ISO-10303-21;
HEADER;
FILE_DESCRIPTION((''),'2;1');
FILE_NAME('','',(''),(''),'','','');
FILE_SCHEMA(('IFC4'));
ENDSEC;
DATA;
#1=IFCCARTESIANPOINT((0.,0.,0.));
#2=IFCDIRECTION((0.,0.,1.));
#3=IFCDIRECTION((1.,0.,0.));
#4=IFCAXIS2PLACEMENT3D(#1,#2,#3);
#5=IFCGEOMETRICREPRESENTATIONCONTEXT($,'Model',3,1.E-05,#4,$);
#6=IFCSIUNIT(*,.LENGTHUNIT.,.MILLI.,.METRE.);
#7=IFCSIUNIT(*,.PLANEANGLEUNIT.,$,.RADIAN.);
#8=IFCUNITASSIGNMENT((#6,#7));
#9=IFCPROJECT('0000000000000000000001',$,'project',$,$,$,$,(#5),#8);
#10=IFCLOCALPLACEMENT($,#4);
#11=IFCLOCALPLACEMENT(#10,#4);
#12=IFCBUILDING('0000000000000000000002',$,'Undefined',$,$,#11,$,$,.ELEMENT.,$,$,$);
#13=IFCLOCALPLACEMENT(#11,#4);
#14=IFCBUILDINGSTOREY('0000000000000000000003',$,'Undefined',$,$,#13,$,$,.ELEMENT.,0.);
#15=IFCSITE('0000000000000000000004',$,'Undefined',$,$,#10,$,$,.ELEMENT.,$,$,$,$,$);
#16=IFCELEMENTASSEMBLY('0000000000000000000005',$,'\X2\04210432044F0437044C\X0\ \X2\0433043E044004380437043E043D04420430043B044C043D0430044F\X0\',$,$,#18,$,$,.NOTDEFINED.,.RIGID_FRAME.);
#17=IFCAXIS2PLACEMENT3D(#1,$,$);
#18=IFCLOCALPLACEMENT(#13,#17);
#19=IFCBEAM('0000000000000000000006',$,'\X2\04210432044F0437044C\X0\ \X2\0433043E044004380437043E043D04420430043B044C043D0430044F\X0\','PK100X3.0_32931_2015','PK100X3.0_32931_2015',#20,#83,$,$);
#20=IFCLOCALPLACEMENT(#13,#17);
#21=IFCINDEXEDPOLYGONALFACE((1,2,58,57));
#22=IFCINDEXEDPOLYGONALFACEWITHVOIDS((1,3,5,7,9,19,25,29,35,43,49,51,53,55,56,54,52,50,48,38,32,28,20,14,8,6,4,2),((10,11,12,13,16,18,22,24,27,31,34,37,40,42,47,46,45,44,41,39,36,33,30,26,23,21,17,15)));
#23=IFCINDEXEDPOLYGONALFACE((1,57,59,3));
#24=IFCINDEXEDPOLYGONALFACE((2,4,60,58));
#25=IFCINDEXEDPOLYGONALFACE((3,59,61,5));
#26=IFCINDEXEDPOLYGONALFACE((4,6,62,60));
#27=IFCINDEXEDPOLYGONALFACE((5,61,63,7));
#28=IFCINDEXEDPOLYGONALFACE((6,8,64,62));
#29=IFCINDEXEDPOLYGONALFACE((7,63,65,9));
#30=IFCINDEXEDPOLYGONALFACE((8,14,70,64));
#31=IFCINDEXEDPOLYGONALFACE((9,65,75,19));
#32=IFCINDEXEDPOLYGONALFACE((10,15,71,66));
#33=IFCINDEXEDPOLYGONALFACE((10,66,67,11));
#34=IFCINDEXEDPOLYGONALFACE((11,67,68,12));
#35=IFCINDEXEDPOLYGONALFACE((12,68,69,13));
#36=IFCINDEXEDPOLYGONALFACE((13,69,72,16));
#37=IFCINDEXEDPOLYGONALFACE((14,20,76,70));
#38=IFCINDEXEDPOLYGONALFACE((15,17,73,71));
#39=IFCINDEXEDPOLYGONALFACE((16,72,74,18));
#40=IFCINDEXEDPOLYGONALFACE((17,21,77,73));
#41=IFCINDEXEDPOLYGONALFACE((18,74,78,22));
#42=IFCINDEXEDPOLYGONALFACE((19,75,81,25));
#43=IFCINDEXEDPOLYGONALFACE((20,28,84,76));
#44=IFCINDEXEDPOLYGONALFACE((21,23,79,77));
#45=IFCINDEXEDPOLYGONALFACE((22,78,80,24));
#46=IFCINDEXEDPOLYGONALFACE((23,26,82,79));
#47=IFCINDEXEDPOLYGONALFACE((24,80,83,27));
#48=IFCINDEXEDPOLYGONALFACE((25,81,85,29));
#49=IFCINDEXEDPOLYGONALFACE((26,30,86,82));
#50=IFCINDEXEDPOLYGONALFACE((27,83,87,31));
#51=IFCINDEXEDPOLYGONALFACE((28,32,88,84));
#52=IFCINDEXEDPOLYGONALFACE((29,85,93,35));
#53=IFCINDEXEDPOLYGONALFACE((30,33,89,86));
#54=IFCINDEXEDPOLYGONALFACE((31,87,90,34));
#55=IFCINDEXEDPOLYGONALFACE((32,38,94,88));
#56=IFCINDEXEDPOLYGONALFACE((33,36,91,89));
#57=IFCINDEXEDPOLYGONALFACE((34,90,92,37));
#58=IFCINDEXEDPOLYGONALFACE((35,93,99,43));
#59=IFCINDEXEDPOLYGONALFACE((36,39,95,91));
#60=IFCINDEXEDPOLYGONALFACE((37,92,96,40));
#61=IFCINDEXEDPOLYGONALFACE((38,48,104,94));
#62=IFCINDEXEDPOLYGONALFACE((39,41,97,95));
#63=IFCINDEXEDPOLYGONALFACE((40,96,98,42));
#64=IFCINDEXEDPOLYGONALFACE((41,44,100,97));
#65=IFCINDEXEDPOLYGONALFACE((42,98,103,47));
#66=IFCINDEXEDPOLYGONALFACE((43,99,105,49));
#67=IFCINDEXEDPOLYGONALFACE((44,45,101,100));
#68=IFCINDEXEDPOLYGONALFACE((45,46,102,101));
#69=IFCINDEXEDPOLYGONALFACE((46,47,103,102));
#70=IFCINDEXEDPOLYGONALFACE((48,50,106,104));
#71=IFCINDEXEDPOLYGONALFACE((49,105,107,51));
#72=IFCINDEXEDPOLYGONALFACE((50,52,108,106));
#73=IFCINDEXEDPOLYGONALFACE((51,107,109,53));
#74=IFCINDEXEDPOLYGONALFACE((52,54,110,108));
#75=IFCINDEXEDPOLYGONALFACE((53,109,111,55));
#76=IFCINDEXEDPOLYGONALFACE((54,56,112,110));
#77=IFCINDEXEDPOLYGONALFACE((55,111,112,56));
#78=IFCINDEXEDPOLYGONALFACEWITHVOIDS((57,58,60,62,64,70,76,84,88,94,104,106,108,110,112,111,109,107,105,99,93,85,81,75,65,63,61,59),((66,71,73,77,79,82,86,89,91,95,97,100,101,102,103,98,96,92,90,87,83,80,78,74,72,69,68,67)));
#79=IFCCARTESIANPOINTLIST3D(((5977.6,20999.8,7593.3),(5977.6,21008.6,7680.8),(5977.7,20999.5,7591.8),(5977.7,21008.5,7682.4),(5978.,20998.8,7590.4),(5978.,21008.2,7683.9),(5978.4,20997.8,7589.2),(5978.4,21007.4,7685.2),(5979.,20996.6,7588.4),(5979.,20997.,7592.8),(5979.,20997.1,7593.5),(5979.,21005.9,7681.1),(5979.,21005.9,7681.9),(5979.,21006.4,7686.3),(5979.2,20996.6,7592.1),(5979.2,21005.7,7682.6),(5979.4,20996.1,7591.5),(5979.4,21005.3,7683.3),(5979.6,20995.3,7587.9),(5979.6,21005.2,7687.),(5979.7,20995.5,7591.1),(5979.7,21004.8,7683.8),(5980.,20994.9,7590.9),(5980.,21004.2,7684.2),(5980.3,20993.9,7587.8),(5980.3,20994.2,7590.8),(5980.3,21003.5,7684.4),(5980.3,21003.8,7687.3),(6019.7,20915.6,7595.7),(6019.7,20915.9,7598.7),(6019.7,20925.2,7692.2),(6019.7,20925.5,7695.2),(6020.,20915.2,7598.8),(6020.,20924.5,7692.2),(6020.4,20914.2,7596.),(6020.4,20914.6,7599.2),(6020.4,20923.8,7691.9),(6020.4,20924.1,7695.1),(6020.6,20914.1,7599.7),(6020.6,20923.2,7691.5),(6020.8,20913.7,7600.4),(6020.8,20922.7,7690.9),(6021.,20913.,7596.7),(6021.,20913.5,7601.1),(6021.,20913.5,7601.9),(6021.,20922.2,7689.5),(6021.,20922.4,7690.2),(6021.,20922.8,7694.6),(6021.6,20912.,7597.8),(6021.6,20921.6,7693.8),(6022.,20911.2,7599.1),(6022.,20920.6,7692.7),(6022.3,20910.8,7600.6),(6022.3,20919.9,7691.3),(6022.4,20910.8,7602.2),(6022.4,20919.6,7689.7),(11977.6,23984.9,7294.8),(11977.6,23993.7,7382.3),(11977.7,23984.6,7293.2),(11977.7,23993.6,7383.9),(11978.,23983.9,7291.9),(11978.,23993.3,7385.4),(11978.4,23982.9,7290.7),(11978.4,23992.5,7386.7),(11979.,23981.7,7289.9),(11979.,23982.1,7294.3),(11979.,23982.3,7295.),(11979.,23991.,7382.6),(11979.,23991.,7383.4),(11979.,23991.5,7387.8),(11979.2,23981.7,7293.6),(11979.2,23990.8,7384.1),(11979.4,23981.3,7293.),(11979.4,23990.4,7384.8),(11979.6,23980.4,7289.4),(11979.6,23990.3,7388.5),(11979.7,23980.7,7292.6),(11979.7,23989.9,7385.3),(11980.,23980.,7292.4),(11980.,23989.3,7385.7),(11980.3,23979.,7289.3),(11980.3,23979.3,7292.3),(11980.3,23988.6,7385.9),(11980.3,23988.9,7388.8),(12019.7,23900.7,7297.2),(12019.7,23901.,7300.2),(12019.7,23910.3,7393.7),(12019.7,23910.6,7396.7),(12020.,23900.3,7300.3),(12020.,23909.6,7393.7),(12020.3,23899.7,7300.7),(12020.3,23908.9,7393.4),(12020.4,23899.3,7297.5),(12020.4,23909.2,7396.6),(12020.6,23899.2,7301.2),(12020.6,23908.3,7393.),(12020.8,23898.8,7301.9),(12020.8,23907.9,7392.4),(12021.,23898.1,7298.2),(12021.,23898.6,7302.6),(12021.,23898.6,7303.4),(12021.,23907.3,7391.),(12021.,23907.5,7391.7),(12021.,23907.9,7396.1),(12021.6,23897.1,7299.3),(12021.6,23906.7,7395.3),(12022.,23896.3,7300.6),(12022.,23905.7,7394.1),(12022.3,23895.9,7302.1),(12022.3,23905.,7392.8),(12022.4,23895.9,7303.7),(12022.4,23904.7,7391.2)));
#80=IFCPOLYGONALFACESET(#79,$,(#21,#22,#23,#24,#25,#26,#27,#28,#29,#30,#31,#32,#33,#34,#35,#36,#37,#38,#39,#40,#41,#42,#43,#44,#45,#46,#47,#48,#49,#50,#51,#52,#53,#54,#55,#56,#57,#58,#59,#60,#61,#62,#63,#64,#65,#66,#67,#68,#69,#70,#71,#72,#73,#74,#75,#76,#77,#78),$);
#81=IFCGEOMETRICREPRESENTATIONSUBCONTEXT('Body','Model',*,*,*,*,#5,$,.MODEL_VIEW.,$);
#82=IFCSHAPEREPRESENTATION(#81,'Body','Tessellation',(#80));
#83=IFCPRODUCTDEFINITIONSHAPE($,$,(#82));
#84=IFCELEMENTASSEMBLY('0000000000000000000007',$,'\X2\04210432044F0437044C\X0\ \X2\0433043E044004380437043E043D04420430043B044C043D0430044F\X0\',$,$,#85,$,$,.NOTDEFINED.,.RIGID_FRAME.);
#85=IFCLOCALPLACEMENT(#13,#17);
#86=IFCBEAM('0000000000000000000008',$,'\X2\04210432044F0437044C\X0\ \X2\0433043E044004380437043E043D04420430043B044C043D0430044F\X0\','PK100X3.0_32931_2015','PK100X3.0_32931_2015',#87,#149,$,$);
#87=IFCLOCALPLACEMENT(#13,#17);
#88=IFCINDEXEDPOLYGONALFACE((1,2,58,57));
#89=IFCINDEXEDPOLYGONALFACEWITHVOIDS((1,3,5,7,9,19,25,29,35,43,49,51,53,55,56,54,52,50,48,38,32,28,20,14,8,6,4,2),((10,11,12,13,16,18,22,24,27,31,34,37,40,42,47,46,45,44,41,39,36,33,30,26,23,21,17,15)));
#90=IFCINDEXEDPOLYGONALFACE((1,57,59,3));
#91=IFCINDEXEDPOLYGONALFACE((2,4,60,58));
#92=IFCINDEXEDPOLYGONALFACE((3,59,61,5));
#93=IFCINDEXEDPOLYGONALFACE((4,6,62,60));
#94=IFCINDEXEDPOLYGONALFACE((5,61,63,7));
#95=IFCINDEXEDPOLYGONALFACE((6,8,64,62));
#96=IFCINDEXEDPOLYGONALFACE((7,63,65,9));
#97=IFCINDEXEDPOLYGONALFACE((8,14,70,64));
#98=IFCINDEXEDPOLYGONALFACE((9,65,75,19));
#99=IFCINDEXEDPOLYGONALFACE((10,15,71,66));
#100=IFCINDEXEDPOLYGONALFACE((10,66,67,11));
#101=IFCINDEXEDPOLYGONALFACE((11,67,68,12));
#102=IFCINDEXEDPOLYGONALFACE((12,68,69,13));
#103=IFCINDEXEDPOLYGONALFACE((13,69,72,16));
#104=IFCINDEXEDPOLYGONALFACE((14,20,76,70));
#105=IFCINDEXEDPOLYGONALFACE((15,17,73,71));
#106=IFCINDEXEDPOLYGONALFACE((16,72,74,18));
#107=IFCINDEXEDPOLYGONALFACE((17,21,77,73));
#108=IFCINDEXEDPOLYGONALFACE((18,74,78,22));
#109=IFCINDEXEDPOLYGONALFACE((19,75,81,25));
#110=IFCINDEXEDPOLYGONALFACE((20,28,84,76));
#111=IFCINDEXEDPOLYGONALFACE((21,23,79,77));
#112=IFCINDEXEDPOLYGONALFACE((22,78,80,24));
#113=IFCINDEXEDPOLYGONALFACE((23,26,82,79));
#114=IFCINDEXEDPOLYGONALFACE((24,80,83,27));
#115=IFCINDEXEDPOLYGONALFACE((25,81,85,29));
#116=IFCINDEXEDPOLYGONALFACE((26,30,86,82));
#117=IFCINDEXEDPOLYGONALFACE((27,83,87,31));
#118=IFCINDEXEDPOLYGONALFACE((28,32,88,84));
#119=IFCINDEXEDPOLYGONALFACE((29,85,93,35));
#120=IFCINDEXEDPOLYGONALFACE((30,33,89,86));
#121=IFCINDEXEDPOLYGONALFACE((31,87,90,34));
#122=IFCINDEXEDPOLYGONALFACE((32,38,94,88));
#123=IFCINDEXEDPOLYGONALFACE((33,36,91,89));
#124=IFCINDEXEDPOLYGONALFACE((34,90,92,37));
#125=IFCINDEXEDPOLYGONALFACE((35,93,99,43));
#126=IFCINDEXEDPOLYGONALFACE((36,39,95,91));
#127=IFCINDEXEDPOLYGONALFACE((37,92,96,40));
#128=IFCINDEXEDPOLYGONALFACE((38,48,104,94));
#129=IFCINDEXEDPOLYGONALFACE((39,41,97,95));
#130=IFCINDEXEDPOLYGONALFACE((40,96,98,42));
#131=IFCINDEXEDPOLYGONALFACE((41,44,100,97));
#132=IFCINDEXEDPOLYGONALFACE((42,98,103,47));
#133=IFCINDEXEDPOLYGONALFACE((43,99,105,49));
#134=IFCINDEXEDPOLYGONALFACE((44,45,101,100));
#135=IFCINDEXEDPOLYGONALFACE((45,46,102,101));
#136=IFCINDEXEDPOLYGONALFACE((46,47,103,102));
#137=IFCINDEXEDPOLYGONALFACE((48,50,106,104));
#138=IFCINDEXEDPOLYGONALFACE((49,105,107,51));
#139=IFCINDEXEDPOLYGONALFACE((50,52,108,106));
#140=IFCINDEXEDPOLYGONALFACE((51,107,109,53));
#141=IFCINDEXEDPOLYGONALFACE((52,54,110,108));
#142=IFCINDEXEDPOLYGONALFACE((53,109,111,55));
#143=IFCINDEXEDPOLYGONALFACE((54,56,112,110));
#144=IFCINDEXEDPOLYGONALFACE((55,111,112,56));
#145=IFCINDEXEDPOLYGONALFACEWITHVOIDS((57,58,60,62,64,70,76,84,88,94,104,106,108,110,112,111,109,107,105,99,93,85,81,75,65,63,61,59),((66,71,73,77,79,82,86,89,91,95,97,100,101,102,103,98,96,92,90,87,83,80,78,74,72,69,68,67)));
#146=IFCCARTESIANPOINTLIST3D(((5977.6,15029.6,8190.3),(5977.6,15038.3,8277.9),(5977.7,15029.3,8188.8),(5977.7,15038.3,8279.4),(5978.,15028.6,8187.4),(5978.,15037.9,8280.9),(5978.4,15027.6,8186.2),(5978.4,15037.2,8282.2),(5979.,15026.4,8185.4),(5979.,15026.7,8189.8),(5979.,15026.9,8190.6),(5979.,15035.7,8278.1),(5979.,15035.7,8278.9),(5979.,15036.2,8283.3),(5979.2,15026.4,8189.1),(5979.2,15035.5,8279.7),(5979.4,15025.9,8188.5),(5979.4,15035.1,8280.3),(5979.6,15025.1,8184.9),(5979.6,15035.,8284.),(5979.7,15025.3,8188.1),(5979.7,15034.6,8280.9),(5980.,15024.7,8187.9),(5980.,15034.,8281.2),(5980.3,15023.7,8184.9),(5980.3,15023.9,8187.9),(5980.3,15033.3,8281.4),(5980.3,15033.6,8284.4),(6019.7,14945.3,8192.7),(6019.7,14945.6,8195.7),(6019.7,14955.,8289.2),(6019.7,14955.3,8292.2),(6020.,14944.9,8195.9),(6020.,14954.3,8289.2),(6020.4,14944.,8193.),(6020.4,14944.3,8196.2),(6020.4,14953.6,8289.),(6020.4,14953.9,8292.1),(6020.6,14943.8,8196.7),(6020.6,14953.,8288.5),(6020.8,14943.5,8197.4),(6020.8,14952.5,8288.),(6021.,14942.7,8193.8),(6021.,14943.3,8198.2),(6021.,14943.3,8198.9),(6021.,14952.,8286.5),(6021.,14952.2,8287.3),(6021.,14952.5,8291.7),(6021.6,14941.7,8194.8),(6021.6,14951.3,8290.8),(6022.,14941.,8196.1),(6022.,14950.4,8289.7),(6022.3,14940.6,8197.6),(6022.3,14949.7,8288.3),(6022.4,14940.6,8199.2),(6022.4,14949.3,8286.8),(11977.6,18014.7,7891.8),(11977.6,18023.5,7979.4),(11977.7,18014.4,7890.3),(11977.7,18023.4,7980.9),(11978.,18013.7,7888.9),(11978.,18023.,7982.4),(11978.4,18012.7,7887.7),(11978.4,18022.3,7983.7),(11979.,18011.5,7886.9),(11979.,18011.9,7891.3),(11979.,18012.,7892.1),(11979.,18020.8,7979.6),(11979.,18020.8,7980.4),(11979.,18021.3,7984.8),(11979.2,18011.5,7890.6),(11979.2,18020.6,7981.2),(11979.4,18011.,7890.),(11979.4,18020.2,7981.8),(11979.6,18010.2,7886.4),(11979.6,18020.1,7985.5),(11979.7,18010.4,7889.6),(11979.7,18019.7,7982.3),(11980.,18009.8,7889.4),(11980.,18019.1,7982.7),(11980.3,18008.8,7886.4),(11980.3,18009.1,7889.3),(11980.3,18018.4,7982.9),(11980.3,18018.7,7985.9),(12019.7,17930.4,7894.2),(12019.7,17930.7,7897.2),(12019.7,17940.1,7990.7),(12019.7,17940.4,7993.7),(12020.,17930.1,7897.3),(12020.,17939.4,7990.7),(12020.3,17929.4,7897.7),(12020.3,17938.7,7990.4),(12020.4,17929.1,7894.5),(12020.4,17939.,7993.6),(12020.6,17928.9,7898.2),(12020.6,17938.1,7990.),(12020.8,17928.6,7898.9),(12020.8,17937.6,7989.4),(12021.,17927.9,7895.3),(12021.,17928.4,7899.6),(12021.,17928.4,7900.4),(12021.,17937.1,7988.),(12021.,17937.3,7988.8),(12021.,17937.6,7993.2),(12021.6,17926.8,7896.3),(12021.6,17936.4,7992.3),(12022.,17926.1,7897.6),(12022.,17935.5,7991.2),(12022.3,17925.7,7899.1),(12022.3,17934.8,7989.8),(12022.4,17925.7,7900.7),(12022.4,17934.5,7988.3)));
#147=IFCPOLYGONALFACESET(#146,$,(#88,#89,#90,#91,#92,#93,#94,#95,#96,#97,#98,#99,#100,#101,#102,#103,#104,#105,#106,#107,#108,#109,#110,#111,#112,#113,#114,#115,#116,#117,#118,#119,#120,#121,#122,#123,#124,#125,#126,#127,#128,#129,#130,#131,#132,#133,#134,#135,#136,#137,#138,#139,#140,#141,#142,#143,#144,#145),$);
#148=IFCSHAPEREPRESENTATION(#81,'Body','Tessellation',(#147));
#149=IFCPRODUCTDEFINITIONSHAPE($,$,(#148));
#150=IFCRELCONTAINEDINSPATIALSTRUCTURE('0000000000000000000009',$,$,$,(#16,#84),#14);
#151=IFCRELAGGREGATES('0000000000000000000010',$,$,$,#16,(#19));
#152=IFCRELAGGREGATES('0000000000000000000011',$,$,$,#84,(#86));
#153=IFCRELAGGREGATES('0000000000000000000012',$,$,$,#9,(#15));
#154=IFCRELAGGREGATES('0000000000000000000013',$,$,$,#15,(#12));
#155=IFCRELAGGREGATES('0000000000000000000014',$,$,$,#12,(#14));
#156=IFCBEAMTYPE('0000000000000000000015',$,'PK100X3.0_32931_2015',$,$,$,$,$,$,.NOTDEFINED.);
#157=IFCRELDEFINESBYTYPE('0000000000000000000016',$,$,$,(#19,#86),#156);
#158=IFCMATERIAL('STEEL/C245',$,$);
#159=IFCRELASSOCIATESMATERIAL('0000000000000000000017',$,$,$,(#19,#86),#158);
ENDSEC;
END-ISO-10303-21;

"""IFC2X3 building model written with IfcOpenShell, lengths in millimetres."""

from ifc_helpers import new_model, si_unit, frame, origin_with_axes, origin_2d_with_axis, place, context, subcontext, project, spatial, hollow_rectangle, extrude, material, type_object, element, aggregate, save


model = new_model("IFC2X3")

# Units and contexts
model_context = context("Model", 3, precision=1e-05, world=origin_with_axes())
body_context = subcontext(model_context, "Body", "Model", "MODEL_VIEW")
ifc_project = project(units=[si_unit("LENGTHUNIT", "METRE", prefix="MILLI"), si_unit("PLANEANGLEUNIT", "RADIAN")], contexts=[model_context])

# Site, building, storey
site_placement = place(None, origin_with_axes())
site = spatial("IfcSite", under=ifc_project, at=site_placement, Name="Undefined", CompositionType="ELEMENT")
building_placement = place(site_placement, origin_with_axes())
building = spatial("IfcBuilding", under=site, at=building_placement, Name="Undefined", CompositionType="ELEMENT")
storey_placement = place(building_placement, origin_with_axes())
storey = spatial("IfcBuildingStorey", under=building, at=storey_placement, Name="Undefined", CompositionType="ELEMENT", Elevation=0.0)

# Element assemblies, beams
ifc_material_1 = material(Name="STEEL/C245")
beam_type_1 = type_object("IfcBeamType", Name="PK100X3.0_32931_2015", PredefinedType="NOTDEFINED")
assembly_1_placement = place(storey_placement, origin_with_axes())
assembly_1 = element("IfcElementAssembly", 1, at=assembly_1_placement, inside=storey, Name="Связь горизонтальная", AssemblyPlace="NOTDEFINED", PredefinedType="RIGID_FRAME")
beam_1_placement = place(assembly_1_placement, frame((6000.0, 20959.7, 7641.5), z_axis=(0.0, 0.099504, 0.995037), x_axis=(0.894427, 0.444994, -0.044499)))
beam_1 = element("IfcBeam", 2, at=beam_1_placement, type_object=beam_type_1, material=ifc_material_1, Name="Связь горизонтальная", Description="PK100X3.0_32931_2015", ObjectType="PK100X3.0_32931_2015", context=body_context, shape_type="SweptSolid", body=[
    extrude(hollow_rectangle(XDim=100.0, YDim=100.0, WallThickness=3.0, InnerFilletRadius=3.0, OuterFilletRadius=6.0, at=origin_2d_with_axis()), frame((6708.2, 0.0, 0.0), z_axis=(-1.0, 0.0, 0.0), x_axis=(0.0, -1.0, 0.0)), (0.0, 0.0, 1.0), 6708.2),
])
aggregate(assembly_1, [beam_1])
assembly_2_placement = place(storey_placement, origin_with_axes())
assembly_2 = element("IfcElementAssembly", 3, at=assembly_2_placement, inside=storey, Name="Связь горизонтальная", AssemblyPlace="NOTDEFINED", PredefinedType="RIGID_FRAME")
beam_2_placement = place(assembly_2_placement, frame((6000.0, 14989.5, 8238.5), z_axis=(0.0, 0.099504, 0.995037), x_axis=(0.894427, 0.444994, -0.044499)))
beam_2 = element("IfcBeam", 4, at=beam_2_placement, type_object=beam_type_1, material=ifc_material_1, Name="Связь горизонтальная", Description="PK100X3.0_32931_2015", ObjectType="PK100X3.0_32931_2015", context=body_context, shape_type="SweptSolid", body=[
    extrude(hollow_rectangle(XDim=100.0, YDim=100.0, WallThickness=3.0, InnerFilletRadius=3.0, OuterFilletRadius=6.0, at=origin_2d_with_axis()), frame((6708.2, 0.0, 0.0), z_axis=(-1.0, 0.0, 0.0), x_axis=(0.0, -1.0, 0.0)), (0.0, 0.0, 1.0), 6708.2),
])
aggregate(assembly_2, [beam_2])

save(model, "model.ifc")
